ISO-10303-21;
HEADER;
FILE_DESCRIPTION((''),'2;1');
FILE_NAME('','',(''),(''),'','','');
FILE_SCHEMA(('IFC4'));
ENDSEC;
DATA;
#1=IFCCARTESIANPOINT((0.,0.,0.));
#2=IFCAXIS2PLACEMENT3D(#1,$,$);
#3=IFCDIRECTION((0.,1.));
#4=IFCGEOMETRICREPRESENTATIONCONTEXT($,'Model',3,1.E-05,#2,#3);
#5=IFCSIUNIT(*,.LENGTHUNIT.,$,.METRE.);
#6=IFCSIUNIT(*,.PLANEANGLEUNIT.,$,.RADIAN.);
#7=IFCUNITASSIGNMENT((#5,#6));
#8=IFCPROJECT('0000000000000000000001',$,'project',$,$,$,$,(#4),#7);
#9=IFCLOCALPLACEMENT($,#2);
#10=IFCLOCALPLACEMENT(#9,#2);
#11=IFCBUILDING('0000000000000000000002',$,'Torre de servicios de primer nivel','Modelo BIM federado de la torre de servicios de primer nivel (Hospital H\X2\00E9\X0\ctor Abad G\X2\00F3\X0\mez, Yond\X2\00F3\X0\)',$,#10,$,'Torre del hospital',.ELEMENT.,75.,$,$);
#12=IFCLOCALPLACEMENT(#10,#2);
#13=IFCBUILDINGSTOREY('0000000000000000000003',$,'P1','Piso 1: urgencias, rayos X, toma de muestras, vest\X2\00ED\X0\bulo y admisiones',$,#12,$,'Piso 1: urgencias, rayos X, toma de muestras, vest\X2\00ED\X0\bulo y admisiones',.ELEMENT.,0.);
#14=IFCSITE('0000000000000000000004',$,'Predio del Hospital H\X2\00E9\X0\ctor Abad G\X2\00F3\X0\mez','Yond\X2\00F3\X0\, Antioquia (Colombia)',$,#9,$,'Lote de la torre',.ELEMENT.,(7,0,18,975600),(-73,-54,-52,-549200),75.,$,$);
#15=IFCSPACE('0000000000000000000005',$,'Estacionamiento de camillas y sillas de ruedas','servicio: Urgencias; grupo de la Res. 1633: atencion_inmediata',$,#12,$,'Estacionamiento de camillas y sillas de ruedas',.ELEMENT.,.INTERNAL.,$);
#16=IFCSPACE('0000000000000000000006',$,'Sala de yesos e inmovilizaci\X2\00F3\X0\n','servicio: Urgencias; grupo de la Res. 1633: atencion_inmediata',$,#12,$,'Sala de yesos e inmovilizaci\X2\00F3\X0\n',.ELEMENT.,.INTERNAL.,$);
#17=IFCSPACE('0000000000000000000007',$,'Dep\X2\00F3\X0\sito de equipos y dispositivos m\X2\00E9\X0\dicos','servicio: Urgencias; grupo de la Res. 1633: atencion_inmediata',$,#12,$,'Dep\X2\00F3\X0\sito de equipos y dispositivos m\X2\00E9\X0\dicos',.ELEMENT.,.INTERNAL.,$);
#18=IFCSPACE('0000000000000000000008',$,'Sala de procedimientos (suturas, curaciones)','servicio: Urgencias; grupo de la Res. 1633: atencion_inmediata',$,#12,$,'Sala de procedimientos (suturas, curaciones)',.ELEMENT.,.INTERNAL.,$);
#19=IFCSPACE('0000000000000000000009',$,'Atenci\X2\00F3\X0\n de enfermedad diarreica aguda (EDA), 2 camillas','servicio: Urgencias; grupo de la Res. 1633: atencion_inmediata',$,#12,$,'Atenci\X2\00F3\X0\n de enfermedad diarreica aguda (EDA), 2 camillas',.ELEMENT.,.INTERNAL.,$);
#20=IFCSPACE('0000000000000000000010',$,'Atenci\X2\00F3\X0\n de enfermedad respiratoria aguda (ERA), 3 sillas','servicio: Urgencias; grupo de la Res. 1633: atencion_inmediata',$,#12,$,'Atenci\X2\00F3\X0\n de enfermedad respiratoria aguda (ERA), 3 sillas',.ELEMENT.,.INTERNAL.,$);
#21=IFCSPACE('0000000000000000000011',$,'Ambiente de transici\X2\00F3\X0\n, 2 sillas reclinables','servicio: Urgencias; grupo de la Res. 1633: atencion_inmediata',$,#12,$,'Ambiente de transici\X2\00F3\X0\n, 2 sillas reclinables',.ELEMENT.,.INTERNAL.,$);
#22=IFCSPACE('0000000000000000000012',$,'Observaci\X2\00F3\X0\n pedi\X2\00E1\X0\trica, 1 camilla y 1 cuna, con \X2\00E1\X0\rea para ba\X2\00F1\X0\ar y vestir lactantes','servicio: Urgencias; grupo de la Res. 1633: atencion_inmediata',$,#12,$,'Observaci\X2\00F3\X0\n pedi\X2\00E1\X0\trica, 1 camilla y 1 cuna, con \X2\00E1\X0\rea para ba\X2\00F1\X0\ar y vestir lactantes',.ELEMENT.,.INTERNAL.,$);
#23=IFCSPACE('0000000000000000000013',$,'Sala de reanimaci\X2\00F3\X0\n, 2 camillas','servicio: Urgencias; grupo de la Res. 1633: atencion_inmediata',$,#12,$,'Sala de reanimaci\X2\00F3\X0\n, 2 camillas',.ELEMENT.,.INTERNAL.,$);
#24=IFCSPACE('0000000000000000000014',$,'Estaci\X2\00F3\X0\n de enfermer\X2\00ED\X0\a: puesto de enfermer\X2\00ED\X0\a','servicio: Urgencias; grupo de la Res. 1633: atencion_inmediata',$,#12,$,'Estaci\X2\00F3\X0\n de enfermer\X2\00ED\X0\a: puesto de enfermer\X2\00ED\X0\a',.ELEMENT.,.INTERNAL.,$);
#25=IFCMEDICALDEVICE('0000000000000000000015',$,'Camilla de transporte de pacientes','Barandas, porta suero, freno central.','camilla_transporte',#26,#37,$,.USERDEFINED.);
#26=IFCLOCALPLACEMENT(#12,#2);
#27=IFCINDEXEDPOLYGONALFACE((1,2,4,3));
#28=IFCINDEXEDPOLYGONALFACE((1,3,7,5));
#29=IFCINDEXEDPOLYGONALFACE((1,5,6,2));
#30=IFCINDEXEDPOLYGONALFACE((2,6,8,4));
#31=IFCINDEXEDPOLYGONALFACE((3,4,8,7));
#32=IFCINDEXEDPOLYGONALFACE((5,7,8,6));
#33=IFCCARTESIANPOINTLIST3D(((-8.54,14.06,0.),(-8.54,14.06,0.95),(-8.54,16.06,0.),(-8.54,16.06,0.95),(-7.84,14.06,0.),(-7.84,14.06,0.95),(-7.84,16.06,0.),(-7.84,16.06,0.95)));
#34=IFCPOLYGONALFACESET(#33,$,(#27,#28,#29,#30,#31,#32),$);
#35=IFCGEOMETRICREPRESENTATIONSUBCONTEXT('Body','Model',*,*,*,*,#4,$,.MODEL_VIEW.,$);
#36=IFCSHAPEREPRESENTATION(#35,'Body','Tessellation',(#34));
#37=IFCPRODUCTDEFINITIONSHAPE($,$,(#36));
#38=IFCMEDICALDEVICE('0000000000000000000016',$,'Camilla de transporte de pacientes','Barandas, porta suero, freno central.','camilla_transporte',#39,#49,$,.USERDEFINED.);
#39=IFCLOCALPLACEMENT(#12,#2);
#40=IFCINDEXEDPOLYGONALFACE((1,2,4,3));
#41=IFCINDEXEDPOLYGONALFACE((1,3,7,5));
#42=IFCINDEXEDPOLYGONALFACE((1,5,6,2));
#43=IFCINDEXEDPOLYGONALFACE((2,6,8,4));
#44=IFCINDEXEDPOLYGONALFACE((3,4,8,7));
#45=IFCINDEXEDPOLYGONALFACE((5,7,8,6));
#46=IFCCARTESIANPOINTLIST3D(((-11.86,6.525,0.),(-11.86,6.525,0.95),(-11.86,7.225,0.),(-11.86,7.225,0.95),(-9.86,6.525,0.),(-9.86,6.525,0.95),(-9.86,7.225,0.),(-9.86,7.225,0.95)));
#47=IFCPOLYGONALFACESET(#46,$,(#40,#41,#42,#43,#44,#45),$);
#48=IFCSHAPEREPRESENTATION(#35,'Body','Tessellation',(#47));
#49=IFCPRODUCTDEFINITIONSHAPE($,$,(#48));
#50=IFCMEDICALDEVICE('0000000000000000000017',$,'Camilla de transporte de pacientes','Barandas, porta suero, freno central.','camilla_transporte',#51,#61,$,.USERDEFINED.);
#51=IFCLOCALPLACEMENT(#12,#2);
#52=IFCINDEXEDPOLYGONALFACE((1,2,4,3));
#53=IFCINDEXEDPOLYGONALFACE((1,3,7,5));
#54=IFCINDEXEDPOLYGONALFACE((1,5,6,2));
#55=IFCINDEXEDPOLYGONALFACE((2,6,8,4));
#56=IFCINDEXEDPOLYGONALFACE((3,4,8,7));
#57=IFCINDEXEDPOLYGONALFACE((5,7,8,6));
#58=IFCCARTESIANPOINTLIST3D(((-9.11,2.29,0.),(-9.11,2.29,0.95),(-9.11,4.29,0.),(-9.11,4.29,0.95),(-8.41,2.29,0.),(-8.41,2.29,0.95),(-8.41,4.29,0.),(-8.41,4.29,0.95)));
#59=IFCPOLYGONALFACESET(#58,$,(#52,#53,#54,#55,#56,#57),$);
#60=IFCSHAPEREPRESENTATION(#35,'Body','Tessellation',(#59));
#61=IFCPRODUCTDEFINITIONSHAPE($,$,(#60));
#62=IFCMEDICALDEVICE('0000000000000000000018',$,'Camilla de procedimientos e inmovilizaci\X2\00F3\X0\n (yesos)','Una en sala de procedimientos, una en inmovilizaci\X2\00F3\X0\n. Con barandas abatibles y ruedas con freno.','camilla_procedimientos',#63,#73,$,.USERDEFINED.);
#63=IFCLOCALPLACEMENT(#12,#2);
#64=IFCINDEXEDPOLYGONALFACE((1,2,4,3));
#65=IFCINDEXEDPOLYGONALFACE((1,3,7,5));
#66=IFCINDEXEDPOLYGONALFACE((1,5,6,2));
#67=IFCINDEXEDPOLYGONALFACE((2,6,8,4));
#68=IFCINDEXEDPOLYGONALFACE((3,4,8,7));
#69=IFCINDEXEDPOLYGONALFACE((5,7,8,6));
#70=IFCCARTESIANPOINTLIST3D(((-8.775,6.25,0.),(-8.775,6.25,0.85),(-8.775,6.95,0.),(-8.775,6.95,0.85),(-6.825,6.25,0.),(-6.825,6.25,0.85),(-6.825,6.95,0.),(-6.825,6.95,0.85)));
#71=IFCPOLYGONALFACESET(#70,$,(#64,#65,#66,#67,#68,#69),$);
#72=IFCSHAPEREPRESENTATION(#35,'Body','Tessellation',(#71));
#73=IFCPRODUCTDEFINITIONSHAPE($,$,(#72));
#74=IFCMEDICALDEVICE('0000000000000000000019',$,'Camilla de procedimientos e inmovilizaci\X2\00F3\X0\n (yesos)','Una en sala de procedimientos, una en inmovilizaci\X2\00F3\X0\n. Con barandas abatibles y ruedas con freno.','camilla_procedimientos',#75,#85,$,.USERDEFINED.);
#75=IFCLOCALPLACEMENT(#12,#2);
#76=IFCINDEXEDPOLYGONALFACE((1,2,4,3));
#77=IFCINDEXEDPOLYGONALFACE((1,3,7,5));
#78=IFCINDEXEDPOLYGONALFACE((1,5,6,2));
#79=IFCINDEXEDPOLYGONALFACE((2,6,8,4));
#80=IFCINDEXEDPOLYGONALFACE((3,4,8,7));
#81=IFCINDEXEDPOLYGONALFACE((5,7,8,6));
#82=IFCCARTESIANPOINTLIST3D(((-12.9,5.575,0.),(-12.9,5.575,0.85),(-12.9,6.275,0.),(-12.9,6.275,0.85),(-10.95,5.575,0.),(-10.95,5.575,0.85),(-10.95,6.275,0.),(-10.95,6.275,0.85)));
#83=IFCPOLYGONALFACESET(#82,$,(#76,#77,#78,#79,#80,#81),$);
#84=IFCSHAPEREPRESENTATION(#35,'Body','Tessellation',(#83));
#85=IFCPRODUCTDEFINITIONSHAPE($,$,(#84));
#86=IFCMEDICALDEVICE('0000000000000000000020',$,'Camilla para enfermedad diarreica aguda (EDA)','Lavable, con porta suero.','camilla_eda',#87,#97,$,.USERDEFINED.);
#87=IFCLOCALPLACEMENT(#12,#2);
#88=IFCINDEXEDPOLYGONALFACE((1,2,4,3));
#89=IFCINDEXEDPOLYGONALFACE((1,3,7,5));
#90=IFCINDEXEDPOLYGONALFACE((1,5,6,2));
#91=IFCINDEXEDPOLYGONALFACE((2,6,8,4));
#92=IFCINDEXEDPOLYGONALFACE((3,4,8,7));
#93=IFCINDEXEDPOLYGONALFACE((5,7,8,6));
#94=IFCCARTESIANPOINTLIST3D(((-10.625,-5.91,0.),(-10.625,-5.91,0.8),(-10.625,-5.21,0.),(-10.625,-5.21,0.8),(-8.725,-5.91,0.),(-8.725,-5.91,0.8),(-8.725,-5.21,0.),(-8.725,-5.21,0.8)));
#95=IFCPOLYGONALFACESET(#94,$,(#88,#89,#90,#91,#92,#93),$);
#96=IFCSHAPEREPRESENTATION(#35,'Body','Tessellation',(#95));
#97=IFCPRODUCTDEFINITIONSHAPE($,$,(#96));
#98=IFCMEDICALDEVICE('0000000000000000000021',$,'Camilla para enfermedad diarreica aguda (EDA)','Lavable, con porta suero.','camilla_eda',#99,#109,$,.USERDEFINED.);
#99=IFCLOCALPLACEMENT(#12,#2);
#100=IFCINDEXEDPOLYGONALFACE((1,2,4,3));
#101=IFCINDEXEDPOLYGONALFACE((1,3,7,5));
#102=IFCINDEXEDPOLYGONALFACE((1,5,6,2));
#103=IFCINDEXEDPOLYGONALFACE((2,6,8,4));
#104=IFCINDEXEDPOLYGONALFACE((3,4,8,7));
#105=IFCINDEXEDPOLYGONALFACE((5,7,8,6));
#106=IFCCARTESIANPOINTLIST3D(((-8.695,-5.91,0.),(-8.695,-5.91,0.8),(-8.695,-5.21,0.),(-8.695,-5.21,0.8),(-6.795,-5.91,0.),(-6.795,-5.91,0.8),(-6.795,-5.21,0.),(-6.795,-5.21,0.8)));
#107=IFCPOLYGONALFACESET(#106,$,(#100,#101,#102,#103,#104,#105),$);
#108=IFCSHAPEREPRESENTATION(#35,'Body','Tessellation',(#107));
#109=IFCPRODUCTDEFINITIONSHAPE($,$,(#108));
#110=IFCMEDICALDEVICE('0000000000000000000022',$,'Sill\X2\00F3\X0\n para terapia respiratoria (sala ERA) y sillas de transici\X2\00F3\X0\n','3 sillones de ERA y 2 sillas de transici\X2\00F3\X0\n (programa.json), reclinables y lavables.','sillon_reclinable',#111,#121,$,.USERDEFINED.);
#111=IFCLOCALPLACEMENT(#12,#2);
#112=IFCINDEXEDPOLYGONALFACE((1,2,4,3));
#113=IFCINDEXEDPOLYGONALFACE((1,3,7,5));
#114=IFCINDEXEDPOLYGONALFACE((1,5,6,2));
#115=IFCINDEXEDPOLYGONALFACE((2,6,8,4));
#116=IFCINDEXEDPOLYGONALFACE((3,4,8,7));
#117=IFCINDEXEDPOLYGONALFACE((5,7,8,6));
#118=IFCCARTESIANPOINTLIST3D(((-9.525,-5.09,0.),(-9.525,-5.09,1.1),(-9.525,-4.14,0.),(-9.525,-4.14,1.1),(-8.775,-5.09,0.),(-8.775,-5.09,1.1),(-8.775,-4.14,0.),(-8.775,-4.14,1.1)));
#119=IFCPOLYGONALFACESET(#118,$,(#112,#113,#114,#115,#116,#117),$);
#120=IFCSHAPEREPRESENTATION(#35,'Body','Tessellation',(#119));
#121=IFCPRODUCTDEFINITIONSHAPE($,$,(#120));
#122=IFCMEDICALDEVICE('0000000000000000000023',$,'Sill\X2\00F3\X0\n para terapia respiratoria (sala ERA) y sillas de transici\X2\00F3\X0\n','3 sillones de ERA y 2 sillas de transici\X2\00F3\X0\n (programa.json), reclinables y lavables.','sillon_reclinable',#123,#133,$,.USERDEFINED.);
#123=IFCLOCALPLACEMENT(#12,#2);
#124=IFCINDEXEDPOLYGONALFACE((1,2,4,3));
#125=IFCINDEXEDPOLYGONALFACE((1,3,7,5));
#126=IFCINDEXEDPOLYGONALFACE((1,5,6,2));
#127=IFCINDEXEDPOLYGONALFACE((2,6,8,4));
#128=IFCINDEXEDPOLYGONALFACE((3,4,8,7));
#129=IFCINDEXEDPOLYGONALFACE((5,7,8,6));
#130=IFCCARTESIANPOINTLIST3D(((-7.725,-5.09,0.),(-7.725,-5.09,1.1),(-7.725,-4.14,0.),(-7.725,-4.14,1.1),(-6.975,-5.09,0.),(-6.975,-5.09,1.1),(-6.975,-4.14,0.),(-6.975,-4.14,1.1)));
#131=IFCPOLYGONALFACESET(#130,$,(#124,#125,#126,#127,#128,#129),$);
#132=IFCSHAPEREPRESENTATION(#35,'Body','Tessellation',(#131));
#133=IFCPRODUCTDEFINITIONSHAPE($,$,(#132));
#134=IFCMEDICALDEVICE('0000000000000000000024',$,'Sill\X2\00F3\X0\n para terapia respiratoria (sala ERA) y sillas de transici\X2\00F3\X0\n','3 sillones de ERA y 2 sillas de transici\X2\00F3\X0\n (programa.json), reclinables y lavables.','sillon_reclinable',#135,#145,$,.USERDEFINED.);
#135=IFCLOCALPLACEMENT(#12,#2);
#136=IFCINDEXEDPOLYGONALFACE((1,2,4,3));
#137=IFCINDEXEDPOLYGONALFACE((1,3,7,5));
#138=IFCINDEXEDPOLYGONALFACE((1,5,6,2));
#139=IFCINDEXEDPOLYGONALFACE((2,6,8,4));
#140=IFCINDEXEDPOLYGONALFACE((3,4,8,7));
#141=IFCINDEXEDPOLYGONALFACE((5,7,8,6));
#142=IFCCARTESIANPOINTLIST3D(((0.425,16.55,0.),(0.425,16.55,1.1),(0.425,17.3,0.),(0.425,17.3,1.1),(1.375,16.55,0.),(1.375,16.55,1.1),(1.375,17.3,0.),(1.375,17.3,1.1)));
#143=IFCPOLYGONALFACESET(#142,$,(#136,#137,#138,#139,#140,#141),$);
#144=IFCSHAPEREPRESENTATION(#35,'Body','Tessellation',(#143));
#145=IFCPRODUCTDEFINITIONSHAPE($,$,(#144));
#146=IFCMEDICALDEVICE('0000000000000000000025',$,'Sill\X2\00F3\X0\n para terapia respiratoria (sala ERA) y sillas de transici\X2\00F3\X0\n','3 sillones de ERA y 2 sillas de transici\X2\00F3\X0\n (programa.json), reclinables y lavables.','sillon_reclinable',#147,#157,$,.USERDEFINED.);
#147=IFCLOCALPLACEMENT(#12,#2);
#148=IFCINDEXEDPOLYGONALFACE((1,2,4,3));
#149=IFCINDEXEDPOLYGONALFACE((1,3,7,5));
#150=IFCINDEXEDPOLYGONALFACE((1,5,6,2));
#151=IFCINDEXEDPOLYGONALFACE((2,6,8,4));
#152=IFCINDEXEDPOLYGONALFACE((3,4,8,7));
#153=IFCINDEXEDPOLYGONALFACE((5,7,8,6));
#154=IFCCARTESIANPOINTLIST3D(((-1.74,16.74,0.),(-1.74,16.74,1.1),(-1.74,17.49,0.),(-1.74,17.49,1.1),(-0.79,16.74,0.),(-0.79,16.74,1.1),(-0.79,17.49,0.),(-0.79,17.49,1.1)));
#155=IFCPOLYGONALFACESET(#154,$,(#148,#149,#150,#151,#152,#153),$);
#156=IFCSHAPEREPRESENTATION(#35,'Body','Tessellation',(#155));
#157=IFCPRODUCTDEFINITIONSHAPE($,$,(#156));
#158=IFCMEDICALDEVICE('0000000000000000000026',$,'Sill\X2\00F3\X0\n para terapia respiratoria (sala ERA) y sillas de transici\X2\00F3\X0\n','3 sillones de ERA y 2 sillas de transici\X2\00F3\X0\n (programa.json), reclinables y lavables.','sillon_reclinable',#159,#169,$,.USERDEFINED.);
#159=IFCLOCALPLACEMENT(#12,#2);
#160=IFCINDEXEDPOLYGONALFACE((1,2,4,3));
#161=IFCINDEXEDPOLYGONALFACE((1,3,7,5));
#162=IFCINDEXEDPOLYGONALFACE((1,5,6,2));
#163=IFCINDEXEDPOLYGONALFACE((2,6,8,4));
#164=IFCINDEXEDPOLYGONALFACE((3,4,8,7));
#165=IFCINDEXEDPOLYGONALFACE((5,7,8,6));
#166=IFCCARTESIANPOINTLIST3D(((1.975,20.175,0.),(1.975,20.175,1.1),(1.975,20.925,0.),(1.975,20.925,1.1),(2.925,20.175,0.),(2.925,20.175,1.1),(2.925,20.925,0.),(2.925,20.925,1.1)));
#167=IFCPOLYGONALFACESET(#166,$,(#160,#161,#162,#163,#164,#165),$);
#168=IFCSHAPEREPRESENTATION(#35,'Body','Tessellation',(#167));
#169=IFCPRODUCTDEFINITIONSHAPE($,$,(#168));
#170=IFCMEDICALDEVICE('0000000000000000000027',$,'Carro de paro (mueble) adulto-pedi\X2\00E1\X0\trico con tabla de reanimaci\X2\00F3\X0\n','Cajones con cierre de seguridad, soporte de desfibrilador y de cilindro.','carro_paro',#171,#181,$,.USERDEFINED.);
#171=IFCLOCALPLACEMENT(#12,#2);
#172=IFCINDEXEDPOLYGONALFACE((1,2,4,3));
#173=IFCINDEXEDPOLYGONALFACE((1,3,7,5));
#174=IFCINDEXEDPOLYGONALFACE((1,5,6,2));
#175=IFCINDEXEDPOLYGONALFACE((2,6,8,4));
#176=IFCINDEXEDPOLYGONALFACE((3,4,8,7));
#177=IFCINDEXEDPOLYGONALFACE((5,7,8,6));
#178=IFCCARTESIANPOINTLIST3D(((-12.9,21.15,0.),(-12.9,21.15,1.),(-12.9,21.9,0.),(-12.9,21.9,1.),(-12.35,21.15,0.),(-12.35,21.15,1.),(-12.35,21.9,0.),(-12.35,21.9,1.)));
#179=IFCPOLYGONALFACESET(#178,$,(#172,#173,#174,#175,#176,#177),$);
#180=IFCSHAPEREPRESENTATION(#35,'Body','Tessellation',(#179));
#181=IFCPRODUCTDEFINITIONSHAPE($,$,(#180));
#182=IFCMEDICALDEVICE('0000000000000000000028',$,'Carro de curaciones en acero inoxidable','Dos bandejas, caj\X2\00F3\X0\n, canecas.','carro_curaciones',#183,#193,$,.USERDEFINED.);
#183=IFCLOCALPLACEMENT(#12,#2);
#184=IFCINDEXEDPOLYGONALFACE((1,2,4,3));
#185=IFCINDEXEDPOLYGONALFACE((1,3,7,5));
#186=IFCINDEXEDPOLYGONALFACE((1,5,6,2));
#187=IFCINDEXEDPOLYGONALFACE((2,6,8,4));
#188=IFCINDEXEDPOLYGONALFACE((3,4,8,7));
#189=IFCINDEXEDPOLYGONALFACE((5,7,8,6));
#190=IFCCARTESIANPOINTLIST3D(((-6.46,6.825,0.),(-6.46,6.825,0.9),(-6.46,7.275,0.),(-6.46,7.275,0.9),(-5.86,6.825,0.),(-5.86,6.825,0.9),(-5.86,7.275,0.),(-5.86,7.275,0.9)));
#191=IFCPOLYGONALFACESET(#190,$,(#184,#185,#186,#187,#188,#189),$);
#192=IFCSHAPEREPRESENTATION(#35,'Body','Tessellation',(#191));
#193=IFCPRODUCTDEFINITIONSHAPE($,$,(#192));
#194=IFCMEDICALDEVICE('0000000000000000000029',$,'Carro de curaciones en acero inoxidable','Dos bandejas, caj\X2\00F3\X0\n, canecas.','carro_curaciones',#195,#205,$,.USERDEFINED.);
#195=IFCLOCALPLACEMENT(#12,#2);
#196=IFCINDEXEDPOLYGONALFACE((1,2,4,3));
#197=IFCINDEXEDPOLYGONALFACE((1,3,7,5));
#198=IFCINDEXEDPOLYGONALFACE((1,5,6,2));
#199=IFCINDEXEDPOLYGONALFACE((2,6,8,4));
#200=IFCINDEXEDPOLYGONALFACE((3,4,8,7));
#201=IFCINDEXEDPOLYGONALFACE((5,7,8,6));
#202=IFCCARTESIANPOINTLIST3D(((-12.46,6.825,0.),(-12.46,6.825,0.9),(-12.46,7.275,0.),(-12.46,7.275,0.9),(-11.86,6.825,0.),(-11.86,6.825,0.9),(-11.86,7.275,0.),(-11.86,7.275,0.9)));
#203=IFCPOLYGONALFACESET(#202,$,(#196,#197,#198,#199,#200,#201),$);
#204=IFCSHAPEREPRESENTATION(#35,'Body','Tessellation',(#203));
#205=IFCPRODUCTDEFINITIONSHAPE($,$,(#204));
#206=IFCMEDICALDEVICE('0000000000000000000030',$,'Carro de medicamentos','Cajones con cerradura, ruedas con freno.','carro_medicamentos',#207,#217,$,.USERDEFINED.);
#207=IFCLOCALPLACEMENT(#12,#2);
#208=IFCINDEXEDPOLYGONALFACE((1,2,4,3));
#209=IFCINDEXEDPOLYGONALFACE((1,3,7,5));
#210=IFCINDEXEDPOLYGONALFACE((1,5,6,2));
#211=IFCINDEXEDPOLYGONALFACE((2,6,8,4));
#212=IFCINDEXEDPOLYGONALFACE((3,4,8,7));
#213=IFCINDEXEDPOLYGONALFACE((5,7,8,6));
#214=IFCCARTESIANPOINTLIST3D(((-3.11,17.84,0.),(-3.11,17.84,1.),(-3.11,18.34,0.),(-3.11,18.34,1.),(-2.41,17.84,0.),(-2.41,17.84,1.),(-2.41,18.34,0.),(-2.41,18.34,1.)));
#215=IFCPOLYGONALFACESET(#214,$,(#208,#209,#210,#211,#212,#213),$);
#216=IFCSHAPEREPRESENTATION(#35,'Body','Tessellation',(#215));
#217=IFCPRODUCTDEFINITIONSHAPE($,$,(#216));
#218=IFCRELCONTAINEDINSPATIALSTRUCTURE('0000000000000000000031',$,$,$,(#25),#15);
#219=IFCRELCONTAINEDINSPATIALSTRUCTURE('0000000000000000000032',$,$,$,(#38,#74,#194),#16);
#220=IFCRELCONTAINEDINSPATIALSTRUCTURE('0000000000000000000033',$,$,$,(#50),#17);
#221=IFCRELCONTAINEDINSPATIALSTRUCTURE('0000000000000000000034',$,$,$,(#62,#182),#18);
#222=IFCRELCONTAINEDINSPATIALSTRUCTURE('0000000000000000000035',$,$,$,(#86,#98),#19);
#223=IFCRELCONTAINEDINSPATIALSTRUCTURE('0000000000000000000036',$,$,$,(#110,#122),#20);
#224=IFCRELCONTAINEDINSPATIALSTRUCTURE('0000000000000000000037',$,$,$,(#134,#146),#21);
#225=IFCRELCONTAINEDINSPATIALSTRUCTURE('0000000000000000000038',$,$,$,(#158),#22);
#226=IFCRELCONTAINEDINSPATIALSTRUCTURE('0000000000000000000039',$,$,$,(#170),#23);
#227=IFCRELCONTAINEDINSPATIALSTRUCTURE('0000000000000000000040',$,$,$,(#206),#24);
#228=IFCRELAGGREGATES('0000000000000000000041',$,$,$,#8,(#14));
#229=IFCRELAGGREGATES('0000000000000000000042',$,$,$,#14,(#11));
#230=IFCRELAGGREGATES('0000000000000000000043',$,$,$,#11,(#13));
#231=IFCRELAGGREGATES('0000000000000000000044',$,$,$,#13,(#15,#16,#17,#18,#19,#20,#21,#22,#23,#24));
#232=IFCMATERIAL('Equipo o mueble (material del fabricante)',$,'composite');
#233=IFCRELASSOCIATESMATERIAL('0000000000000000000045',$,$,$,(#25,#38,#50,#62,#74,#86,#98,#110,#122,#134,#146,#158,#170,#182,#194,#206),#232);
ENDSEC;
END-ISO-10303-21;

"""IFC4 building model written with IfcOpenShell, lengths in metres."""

from ifc_helpers import new_model, si_unit, direction, frame, origin, place, context, subcontext, project, spatial, rectangle, extrude, material, element, save


model = new_model("IFC4")

# Units and contexts
model_context = context("Model", 3, precision=1e-05, world=origin(), true_north=direction((0.0, 1.0)))
body_context = subcontext(model_context, "Body", "Model", "MODEL_VIEW")
ifc_project = project(units=[si_unit("LENGTHUNIT", "METRE"), si_unit("PLANEANGLEUNIT", "RADIAN")], contexts=[model_context])

# Site, building, storey, space
site_placement = place(None, origin())
site = spatial("IfcSite", under=ifc_project, at=site_placement, Name="Predio del Hospital Héctor Abad Gómez", Description="Yondó, Antioquia (Colombia)", LongName="Lote de la torre", CompositionType="ELEMENT", RefLatitude=(7, 0, 18, 975600), RefLongitude=(-73, -54, -52, -549200), RefElevation=75.0)
building_placement = place(site_placement, origin())
building = spatial("IfcBuilding", under=site, at=building_placement, Name="Torre de servicios de primer nivel", Description="Modelo BIM federado de la torre de servicios de primer nivel (Hospital Héctor Abad Gómez, Yondó)", LongName="Torre del hospital", CompositionType="ELEMENT", ElevationOfRefHeight=75.0)
placement = place(building_placement, origin())
storey = spatial("IfcBuildingStorey", under=building, at=placement, Name="P1", Description="Piso 1: urgencias, rayos X, toma de muestras, vestíbulo y admisiones", LongName="Piso 1: urgencias, rayos X, toma de muestras, vestíbulo y admisiones", CompositionType="ELEMENT", Elevation=0.0)
space_1 = spatial("IfcSpace", under=storey, at=placement, Name="Estacionamiento de camillas y sillas de ruedas", Description="servicio: Urgencias; grupo de la Res. 1633: atencion_inmediata", LongName="Estacionamiento de camillas y sillas de ruedas", CompositionType="ELEMENT", PredefinedType="INTERNAL")

# Medical device
ifc_material = material(Name="Equipo o mueble (material del fabricante)", Category="composite")
element("IfcMedicalDevice", 1, at=placement, inside=space_1, material=ifc_material, Name="Camilla de transporte de pacientes", Description="Barandas, porta suero, freno central.", ObjectType="camilla_transporte", PredefinedType="USERDEFINED", context=body_context, shape_type="SweptSolid", body=[
    extrude(rectangle(XDim=0.7, YDim=2.0), frame((-8.19, 15.06, 0.0)), (0.0, 0.0, 1.0), 0.95),
])

# Shared definitions
space_2 = spatial("IfcSpace", under=storey, at=placement, Name="Sala de yesos e inmovilización", Description="servicio: Urgencias; grupo de la Res. 1633: atencion_inmediata", LongName="Sala de yesos e inmovilización", CompositionType="ELEMENT", PredefinedType="INTERNAL")

# Medical device
element("IfcMedicalDevice", 2, at=placement, inside=space_2, material=ifc_material, Name="Camilla de transporte de pacientes", Description="Barandas, porta suero, freno central.", ObjectType="camilla_transporte", PredefinedType="USERDEFINED", context=body_context, shape_type="SweptSolid", body=[
    extrude(rectangle(XDim=0.7, YDim=2.0), frame((-10.86, 6.875, 0.0), z_axis=(0.0, 0.0, 1.0), x_axis=(0.0, 1.0, 0.0)), (0.0, 0.0, 1.0), 0.95),
])

# Shared definitions
space_3 = spatial("IfcSpace", under=storey, at=placement, Name="Depósito de equipos y dispositivos médicos", Description="servicio: Urgencias; grupo de la Res. 1633: atencion_inmediata", LongName="Depósito de equipos y dispositivos médicos", CompositionType="ELEMENT", PredefinedType="INTERNAL")

# Medical device
element("IfcMedicalDevice", 3, at=placement, inside=space_3, material=ifc_material, Name="Camilla de transporte de pacientes", Description="Barandas, porta suero, freno central.", ObjectType="camilla_transporte", PredefinedType="USERDEFINED", context=body_context, shape_type="SweptSolid", body=[
    extrude(rectangle(XDim=0.7, YDim=2.0), frame((-8.76, 3.29, 0.0), z_axis=(0.0, 0.0, 1.0), x_axis=(-1.0, 0.0, 0.0)), (0.0, 0.0, 1.0), 0.95),
])

# Shared definitions
space_4 = spatial("IfcSpace", under=storey, at=placement, Name="Sala de procedimientos (suturas, curaciones)", Description="servicio: Urgencias; grupo de la Res. 1633: atencion_inmediata", LongName="Sala de procedimientos (suturas, curaciones)", CompositionType="ELEMENT", PredefinedType="INTERNAL")

# Medical devices
element("IfcMedicalDevice", 4, at=placement, inside=space_4, material=ifc_material, Name="Camilla de procedimientos e inmovilización (yesos)", Description="Una en sala de procedimientos, una en inmovilización. Con barandas abatibles y ruedas con freno.", ObjectType="camilla_procedimientos", PredefinedType="USERDEFINED", context=body_context, shape_type="SweptSolid", body=[
    extrude(rectangle(XDim=0.7, YDim=1.95), frame((-7.8, 6.6, 0.0), z_axis=(0.0, 0.0, 1.0), x_axis=(0.0, 1.0, 0.0)), (0.0, 0.0, 1.0), 0.85),
])
element("IfcMedicalDevice", 5, at=placement, inside=space_2, material=ifc_material, Name="Camilla de procedimientos e inmovilización (yesos)", Description="Una en sala de procedimientos, una en inmovilización. Con barandas abatibles y ruedas con freno.", ObjectType="camilla_procedimientos", PredefinedType="USERDEFINED", context=body_context, shape_type="SweptSolid", body=[
    extrude(rectangle(XDim=0.7, YDim=1.95), frame((-11.925, 5.925, 0.0), z_axis=(0.0, 0.0, 1.0), x_axis=(0.0, -1.0, 0.0)), (0.0, 0.0, 1.0), 0.85),
])

# Shared definitions
space_5 = spatial("IfcSpace", under=storey, at=placement, Name="Atención de enfermedad diarreica aguda (EDA), 2 camillas", Description="servicio: Urgencias; grupo de la Res. 1633: atencion_inmediata", LongName="Atención de enfermedad diarreica aguda (EDA), 2 camillas", CompositionType="ELEMENT", PredefinedType="INTERNAL")

# Medical devices
element("IfcMedicalDevice", 6, at=placement, inside=space_5, material=ifc_material, Name="Camilla para enfermedad diarreica aguda (EDA)", Description="Lavable, con porta suero.", ObjectType="camilla_eda", PredefinedType="USERDEFINED", context=body_context, shape_type="SweptSolid", body=[
    extrude(rectangle(XDim=0.7, YDim=1.9), frame((-9.675, -5.56, 0.0), z_axis=(0.0, 0.0, 1.0), x_axis=(0.0, -1.0, 0.0)), (0.0, 0.0, 1.0), 0.8),
])
element("IfcMedicalDevice", 7, at=placement, inside=space_5, material=ifc_material, Name="Camilla para enfermedad diarreica aguda (EDA)", Description="Lavable, con porta suero.", ObjectType="camilla_eda", PredefinedType="USERDEFINED", context=body_context, shape_type="SweptSolid", body=[
    extrude(rectangle(XDim=0.7, YDim=1.9), frame((-7.745, -5.56, 0.0), z_axis=(0.0, 0.0, 1.0), x_axis=(0.0, -1.0, 0.0)), (0.0, 0.0, 1.0), 0.8),
])

# Shared definitions
space_6 = spatial("IfcSpace", under=storey, at=placement, Name="Atención de enfermedad respiratoria aguda (ERA), 3 sillas", Description="servicio: Urgencias; grupo de la Res. 1633: atencion_inmediata", LongName="Atención de enfermedad respiratoria aguda (ERA), 3 sillas", CompositionType="ELEMENT", PredefinedType="INTERNAL")

# Medical devices
element("IfcMedicalDevice", 8, at=placement, inside=space_6, material=ifc_material, Name="Sillón para terapia respiratoria (sala ERA) y sillas de transición", Description="3 sillones de ERA y 2 sillas de transición (programa.json), reclinables y lavables.", ObjectType="sillon_reclinable", PredefinedType="USERDEFINED", context=body_context, shape_type="SweptSolid", body=[
    extrude(rectangle(XDim=0.75, YDim=0.95), frame((-9.15, -4.615, 0.0)), (0.0, 0.0, 1.0), 1.1),
])
element("IfcMedicalDevice", 9, at=placement, inside=space_6, material=ifc_material, Name="Sillón para terapia respiratoria (sala ERA) y sillas de transición", Description="3 sillones de ERA y 2 sillas de transición (programa.json), reclinables y lavables.", ObjectType="sillon_reclinable", PredefinedType="USERDEFINED", context=body_context, shape_type="SweptSolid", body=[
    extrude(rectangle(XDim=0.75, YDim=0.95), frame((-7.35, -4.615, 0.0)), (0.0, 0.0, 1.0), 1.1),
])

# Shared definitions
space_7 = spatial("IfcSpace", under=storey, at=placement, Name="Ambiente de transición, 2 sillas reclinables", Description="servicio: Urgencias; grupo de la Res. 1633: atencion_inmediata", LongName="Ambiente de transición, 2 sillas reclinables", CompositionType="ELEMENT", PredefinedType="INTERNAL")

# Medical devices
element("IfcMedicalDevice", 10, at=placement, inside=space_7, material=ifc_material, Name="Sillón para terapia respiratoria (sala ERA) y sillas de transición", Description="3 sillones de ERA y 2 sillas de transición (programa.json), reclinables y lavables.", ObjectType="sillon_reclinable", PredefinedType="USERDEFINED", context=body_context, shape_type="SweptSolid", body=[
    extrude(rectangle(XDim=0.75, YDim=0.95), frame((0.9, 16.925, 0.0), z_axis=(0.0, 0.0, 1.0), x_axis=(0.0, 1.0, 0.0)), (0.0, 0.0, 1.0), 1.1),
])
element("IfcMedicalDevice", 11, at=placement, inside=space_7, material=ifc_material, Name="Sillón para terapia respiratoria (sala ERA) y sillas de transición", Description="3 sillones de ERA y 2 sillas de transición (programa.json), reclinables y lavables.", ObjectType="sillon_reclinable", PredefinedType="USERDEFINED", context=body_context, shape_type="SweptSolid", body=[
    extrude(rectangle(XDim=0.75, YDim=0.95), frame((-1.265, 17.115, 0.0), z_axis=(0.0, 0.0, 1.0), x_axis=(0.0, -1.0, 0.0)), (0.0, 0.0, 1.0), 1.1),
])

# Shared definitions
space_8 = spatial("IfcSpace", under=storey, at=placement, Name="Observación pediátrica, 1 camilla y 1 cuna, con área para bañar y vestir lactantes", Description="servicio: Urgencias; grupo de la Res. 1633: atencion_inmediata", LongName="Observación pediátrica, 1 camilla y 1 cuna, con área para bañar y vestir lactantes", CompositionType="ELEMENT", PredefinedType="INTERNAL")

# Medical device
element("IfcMedicalDevice", 12, at=placement, inside=space_8, material=ifc_material, Name="Sillón para terapia respiratoria (sala ERA) y sillas de transición", Description="3 sillones de ERA y 2 sillas de transición (programa.json), reclinables y lavables.", ObjectType="sillon_reclinable", PredefinedType="USERDEFINED", context=body_context, shape_type="SweptSolid", body=[
    extrude(rectangle(XDim=0.75, YDim=0.95), frame((2.45, 20.55, 0.0), z_axis=(0.0, 0.0, 1.0), x_axis=(0.0, 1.0, 0.0)), (0.0, 0.0, 1.0), 1.1),
])

# Shared definitions
space_9 = spatial("IfcSpace", under=storey, at=placement, Name="Sala de reanimación, 2 camillas", Description="servicio: Urgencias; grupo de la Res. 1633: atencion_inmediata", LongName="Sala de reanimación, 2 camillas", CompositionType="ELEMENT", PredefinedType="INTERNAL")

# Medical devices
element("IfcMedicalDevice", 13, at=placement, inside=space_9, material=ifc_material, Name="Carro de paro (mueble) adulto-pediátrico con tabla de reanimación", Description="Cajones con cierre de seguridad, soporte de desfibrilador y de cilindro.", ObjectType="carro_paro", PredefinedType="USERDEFINED", context=body_context, shape_type="SweptSolid", body=[
    extrude(rectangle(XDim=0.75, YDim=0.55), frame((-12.625, 21.525, 0.0), z_axis=(0.0, 0.0, 1.0), x_axis=(0.0, -1.0, 0.0)), (0.0, 0.0, 1.0), 1.0),
])
element("IfcMedicalDevice", 14, at=placement, inside=space_4, material=ifc_material, Name="Carro de curaciones en acero inoxidable", Description="Dos bandejas, cajón, canecas.", ObjectType="carro_curaciones", PredefinedType="USERDEFINED", context=body_context, shape_type="SweptSolid", body=[
    extrude(rectangle(XDim=0.6, YDim=0.45), frame((-6.16, 7.05, 0.0), z_axis=(0.0, 0.0, 1.0), x_axis=(-1.0, 0.0, 0.0)), (0.0, 0.0, 1.0), 0.9),
])
element("IfcMedicalDevice", 15, at=placement, inside=space_2, material=ifc_material, Name="Carro de curaciones en acero inoxidable", Description="Dos bandejas, cajón, canecas.", ObjectType="carro_curaciones", PredefinedType="USERDEFINED", context=body_context, shape_type="SweptSolid", body=[
    extrude(rectangle(XDim=0.6, YDim=0.45), frame((-12.16, 7.05, 0.0), z_axis=(0.0, 0.0, 1.0), x_axis=(-1.0, 0.0, 0.0)), (0.0, 0.0, 1.0), 0.9),
])

# Shared definitions
space_10 = spatial("IfcSpace", under=storey, at=placement, Name="Estación de enfermería: puesto de enfermería", Description="servicio: Urgencias; grupo de la Res. 1633: atencion_inmediata", LongName="Estación de enfermería: puesto de enfermería", CompositionType="ELEMENT", PredefinedType="INTERNAL")

# Medical device
element("IfcMedicalDevice", 16, at=placement, inside=space_10, material=ifc_material, Name="Carro de medicamentos", Description="Cajones con cerradura, ruedas con freno.", ObjectType="carro_medicamentos", PredefinedType="USERDEFINED", context=body_context, shape_type="SweptSolid", body=[
    extrude(rectangle(XDim=0.7, YDim=0.5), frame((-2.76, 18.09, 0.0), z_axis=(0.0, 0.0, 1.0), x_axis=(-1.0, 0.0, 0.0)), (0.0, 0.0, 1.0), 1.0),
])

save(model, "model.ifc")
